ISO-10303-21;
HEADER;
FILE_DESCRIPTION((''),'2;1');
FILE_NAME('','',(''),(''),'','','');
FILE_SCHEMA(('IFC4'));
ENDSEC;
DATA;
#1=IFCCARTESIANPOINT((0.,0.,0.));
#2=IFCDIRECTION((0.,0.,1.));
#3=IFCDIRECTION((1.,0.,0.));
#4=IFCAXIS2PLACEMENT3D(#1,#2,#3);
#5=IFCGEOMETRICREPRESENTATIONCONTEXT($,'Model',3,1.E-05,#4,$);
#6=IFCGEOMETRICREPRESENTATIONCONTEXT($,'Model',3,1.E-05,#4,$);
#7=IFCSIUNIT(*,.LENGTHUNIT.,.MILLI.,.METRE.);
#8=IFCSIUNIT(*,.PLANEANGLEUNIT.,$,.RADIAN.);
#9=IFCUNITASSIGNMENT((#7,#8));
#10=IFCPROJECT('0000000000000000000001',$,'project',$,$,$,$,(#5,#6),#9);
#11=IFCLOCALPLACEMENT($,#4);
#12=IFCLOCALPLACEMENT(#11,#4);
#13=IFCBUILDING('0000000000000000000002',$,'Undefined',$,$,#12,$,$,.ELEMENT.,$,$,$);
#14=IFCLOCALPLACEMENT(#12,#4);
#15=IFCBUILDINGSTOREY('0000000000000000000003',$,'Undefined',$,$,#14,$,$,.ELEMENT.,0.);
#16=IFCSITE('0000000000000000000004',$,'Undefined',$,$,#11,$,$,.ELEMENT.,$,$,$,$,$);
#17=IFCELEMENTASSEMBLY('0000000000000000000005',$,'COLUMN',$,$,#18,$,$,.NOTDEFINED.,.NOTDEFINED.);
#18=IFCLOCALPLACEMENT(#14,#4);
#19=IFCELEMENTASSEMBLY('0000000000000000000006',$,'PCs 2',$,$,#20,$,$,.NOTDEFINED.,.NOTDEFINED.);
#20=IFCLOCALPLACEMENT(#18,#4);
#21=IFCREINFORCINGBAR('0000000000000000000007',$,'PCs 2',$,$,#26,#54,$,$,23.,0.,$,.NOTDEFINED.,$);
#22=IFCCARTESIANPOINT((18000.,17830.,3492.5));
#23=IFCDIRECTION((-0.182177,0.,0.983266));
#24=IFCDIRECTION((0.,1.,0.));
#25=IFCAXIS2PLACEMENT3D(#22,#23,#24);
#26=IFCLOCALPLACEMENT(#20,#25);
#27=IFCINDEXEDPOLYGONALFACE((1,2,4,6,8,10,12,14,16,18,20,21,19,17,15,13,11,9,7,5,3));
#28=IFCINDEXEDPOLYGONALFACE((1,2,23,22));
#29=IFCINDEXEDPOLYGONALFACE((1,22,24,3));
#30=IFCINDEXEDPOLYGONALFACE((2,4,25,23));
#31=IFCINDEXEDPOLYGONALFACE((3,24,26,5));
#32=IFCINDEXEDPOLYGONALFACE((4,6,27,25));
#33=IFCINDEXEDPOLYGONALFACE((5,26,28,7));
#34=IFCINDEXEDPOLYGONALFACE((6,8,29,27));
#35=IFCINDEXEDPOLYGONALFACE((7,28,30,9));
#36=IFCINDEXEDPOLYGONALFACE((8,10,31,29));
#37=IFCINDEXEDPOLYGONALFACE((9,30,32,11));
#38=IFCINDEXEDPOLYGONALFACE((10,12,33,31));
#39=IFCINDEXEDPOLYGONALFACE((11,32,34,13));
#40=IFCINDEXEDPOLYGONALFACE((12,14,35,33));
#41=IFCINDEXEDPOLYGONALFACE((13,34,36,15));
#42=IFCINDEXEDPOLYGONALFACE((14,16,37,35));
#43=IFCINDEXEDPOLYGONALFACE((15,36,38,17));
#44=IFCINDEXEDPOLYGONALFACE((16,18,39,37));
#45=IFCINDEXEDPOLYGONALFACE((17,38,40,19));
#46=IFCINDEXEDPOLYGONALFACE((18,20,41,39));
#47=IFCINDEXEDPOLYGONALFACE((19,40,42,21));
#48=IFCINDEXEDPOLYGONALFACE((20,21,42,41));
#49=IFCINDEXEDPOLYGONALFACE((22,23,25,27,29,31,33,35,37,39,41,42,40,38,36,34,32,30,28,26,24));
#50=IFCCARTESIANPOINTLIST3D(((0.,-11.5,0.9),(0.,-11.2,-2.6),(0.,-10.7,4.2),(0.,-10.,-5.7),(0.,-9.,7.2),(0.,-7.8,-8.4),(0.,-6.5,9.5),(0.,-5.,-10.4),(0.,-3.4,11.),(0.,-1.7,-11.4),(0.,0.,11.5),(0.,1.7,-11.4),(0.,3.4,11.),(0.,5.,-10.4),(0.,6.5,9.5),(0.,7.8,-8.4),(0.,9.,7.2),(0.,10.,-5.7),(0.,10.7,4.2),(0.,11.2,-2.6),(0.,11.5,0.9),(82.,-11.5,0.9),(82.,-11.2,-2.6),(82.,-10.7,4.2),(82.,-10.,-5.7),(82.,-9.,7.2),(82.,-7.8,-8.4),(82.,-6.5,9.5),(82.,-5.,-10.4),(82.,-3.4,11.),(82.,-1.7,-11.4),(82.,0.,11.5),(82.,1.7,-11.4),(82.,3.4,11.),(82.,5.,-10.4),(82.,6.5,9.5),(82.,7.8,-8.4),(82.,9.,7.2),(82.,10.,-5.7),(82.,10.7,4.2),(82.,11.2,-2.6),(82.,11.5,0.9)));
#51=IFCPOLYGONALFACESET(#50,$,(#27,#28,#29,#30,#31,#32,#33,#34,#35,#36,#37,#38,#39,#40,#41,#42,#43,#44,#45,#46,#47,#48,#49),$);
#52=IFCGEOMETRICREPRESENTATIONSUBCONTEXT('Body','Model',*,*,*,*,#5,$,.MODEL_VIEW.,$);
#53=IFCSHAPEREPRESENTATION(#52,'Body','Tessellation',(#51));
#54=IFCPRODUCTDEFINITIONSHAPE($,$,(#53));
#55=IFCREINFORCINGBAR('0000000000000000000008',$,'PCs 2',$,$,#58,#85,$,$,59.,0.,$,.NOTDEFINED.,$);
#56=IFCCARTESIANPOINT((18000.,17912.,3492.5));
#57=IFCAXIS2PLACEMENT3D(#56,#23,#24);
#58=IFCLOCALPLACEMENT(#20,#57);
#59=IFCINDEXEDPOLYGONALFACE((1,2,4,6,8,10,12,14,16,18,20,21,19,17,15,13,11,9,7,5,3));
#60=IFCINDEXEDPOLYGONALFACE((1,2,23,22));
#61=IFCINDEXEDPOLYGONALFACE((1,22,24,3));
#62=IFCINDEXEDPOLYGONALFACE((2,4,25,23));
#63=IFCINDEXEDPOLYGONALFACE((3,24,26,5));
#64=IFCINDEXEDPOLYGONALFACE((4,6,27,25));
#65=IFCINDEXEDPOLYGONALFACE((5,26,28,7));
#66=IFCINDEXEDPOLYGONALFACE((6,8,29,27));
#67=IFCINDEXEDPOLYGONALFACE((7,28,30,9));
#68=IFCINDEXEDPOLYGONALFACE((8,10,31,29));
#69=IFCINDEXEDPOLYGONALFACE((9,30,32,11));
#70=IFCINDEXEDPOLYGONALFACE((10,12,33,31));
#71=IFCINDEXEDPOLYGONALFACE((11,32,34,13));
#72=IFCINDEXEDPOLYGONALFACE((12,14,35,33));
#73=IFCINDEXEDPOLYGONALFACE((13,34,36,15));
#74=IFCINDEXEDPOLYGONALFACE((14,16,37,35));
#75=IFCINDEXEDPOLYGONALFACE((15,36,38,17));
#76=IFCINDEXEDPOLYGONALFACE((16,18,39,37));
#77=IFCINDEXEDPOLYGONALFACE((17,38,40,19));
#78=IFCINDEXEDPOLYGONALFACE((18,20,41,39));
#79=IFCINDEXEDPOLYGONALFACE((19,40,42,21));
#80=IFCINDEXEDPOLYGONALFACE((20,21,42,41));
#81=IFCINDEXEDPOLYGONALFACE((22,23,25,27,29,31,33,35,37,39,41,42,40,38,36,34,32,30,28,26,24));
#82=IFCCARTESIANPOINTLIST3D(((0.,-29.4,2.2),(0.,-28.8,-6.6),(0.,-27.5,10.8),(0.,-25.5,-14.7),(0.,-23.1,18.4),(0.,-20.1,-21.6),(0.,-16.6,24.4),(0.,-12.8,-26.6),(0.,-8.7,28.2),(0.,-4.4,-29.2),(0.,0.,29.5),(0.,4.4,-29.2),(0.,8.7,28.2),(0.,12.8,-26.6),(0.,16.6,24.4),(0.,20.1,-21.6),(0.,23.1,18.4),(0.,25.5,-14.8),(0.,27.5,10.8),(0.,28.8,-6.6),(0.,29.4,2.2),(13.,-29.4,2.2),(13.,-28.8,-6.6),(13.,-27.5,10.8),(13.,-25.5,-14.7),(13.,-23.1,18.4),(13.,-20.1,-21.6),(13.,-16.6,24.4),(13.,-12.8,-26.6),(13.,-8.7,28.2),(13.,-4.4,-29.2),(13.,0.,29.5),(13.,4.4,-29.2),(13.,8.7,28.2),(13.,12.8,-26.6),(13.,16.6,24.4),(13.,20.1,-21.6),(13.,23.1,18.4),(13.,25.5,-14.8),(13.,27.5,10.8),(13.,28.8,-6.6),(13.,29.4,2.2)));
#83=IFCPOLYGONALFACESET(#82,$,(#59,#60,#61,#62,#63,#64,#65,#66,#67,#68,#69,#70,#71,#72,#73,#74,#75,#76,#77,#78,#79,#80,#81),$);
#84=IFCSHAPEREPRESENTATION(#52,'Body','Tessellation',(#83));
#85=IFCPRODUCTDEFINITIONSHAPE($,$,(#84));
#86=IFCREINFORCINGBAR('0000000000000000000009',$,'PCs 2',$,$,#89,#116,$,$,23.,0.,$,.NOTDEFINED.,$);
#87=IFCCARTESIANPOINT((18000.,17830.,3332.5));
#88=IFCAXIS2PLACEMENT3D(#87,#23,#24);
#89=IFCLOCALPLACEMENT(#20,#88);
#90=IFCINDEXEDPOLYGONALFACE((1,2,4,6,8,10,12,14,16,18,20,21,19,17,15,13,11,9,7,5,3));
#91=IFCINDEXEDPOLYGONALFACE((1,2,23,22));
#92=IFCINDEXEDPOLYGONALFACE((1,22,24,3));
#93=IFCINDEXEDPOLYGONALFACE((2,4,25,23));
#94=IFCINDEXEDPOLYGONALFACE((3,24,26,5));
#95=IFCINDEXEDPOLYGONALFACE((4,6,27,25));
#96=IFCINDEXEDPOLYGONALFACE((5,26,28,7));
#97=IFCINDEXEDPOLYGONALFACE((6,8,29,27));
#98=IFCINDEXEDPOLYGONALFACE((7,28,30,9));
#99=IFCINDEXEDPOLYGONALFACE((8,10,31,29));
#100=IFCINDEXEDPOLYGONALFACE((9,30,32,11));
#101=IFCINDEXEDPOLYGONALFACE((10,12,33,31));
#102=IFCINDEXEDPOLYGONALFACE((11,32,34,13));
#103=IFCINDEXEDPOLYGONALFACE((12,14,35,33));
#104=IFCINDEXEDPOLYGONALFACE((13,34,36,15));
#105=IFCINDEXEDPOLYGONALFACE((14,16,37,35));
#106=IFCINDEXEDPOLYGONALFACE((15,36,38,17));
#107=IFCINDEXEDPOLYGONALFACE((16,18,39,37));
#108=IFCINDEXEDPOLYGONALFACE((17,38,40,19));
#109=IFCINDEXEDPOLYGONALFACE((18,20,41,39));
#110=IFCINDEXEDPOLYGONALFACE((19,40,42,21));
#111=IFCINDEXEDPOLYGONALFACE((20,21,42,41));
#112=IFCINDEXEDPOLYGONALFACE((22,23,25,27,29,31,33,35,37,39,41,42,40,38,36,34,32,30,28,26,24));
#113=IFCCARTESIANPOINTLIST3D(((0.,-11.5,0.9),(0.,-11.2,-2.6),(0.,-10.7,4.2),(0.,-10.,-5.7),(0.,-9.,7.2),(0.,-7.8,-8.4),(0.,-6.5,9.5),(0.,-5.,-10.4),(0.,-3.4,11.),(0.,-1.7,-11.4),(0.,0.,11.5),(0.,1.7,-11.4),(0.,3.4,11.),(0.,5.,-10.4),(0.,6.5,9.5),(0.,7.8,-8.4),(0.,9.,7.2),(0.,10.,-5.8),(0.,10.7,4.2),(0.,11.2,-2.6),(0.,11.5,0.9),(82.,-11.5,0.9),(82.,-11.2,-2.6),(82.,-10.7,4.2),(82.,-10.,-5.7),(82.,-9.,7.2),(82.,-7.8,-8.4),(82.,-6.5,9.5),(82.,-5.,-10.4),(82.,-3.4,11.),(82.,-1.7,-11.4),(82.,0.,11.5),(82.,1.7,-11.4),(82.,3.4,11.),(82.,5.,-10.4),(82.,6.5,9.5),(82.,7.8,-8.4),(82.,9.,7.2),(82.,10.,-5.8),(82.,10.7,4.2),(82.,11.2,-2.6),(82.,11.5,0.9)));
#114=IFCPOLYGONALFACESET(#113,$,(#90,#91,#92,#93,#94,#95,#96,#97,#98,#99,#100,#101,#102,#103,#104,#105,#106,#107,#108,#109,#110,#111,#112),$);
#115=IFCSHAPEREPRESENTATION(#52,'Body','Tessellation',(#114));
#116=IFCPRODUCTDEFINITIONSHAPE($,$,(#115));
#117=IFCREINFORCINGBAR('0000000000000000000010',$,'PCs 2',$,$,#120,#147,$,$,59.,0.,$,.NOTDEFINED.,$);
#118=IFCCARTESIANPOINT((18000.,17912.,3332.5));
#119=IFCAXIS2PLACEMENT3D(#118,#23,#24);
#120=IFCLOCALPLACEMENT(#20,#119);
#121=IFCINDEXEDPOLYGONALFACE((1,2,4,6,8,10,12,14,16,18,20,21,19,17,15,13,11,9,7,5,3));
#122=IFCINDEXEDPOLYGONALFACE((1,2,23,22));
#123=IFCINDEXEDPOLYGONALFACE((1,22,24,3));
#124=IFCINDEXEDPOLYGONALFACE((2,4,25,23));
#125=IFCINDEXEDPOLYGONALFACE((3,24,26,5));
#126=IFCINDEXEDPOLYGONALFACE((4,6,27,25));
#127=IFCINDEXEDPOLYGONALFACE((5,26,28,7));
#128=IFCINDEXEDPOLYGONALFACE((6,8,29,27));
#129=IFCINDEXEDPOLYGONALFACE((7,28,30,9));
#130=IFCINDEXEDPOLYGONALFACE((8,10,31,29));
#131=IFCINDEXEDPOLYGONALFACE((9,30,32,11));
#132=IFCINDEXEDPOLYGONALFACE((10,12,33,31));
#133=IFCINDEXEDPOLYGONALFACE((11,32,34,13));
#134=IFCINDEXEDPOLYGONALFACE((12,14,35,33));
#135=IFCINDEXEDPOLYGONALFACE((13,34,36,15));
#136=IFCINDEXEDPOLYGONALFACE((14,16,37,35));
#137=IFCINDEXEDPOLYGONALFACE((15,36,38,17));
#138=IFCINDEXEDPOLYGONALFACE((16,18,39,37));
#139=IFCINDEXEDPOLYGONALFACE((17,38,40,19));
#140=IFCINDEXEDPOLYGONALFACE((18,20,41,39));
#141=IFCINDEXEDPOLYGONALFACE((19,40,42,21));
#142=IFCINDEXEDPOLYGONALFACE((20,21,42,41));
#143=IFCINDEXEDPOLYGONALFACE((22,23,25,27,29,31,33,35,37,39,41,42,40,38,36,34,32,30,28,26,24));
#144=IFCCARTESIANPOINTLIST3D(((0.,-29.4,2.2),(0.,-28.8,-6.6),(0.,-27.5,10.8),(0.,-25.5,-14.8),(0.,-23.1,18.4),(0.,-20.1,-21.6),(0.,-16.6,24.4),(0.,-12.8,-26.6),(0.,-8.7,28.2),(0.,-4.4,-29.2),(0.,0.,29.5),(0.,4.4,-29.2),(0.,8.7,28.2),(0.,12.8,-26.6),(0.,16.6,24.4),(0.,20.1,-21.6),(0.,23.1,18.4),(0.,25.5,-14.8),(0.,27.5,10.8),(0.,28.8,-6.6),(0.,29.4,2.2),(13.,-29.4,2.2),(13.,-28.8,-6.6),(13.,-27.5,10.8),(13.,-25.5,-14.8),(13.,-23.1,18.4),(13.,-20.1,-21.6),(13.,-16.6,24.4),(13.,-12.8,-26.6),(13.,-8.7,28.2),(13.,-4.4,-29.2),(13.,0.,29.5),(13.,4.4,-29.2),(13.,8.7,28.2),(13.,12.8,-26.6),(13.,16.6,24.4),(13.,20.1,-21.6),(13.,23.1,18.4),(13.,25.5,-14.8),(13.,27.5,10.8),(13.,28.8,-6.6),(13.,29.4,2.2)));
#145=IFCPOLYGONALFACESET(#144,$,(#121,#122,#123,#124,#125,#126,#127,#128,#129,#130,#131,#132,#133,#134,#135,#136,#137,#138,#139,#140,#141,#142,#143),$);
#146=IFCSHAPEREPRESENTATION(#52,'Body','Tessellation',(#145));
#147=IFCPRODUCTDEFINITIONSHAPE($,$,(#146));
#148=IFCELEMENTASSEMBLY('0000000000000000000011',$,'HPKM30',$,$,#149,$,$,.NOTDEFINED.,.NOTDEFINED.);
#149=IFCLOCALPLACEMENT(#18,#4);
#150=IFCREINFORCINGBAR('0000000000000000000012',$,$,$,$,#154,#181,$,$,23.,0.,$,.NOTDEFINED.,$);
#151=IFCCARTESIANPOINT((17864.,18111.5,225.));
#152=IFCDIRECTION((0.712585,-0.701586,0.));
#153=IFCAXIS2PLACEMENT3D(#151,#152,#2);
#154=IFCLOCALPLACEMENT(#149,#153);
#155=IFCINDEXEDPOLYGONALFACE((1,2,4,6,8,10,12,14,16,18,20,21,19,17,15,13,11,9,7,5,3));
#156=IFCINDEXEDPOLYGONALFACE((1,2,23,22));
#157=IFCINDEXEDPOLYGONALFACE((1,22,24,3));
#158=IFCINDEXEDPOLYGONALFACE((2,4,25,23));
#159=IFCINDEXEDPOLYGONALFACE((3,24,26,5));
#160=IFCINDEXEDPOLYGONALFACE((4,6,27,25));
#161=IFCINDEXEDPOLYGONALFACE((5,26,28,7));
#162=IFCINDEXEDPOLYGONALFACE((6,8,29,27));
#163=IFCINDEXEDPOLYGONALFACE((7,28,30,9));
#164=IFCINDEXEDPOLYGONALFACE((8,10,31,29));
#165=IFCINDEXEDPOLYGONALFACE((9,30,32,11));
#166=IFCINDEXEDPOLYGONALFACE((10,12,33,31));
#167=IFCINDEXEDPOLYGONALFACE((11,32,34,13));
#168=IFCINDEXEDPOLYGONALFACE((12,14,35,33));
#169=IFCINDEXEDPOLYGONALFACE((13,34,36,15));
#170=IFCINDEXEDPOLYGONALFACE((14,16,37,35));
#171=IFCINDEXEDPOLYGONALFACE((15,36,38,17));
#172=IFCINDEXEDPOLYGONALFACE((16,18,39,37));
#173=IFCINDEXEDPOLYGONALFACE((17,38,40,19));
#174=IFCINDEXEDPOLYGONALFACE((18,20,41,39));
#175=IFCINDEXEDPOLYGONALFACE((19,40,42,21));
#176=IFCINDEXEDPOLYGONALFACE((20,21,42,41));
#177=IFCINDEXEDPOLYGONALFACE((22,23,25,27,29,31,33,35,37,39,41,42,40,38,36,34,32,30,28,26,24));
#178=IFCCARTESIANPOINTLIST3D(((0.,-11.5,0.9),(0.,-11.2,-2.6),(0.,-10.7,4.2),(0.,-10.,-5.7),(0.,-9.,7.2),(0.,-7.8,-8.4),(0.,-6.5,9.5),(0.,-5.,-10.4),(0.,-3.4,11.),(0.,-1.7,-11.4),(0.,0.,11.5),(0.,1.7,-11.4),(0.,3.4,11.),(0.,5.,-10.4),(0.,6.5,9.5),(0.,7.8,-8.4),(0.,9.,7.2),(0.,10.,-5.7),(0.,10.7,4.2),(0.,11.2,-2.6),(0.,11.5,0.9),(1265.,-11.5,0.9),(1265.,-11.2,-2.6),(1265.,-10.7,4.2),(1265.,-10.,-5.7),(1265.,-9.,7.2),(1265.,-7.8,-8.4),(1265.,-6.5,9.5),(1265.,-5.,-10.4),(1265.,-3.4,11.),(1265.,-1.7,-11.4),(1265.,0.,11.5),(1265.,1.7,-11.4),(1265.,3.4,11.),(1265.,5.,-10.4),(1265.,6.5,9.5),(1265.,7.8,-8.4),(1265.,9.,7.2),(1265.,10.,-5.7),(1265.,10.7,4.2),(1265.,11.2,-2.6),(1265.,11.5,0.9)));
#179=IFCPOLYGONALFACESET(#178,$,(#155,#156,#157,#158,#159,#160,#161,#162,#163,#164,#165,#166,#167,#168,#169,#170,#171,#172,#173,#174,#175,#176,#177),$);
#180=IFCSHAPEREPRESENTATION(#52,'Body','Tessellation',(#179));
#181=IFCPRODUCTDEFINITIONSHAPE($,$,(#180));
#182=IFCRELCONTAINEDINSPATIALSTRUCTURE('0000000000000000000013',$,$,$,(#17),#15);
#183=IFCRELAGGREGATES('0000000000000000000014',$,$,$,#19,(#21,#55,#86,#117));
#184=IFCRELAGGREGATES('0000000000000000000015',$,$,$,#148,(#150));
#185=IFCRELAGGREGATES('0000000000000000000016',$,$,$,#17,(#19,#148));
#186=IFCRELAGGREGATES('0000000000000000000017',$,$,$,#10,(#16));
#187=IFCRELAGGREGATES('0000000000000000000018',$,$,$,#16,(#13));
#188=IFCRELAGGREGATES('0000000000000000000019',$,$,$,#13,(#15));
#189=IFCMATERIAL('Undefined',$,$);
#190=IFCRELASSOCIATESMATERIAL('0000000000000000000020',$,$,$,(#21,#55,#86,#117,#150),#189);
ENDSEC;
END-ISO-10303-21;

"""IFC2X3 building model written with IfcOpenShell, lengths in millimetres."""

from ifc_helpers import new_model, entity, si_unit, frame, origin_with_axes, place, context, subcontext, project, spatial, source, transform, mapped, material, element, aggregate, save


model = new_model("IFC2X3")

# Units and contexts
model_context_1 = context("Model", 3, precision=1e-05, world=origin_with_axes())
model_context_2 = context("Model", 3, precision=1e-05, world=origin_with_axes())
body_context = subcontext(model_context_1, "Body", "Model", "MODEL_VIEW")
ifc_project = project(units=[si_unit("LENGTHUNIT", "METRE", prefix="MILLI"), si_unit("PLANEANGLEUNIT", "RADIAN")], contexts=[model_context_1, model_context_2])

# Site, building, storey
site_placement = place(None, origin_with_axes())
site = spatial("IfcSite", under=ifc_project, at=site_placement, Name="Undefined", CompositionType="ELEMENT")
building_placement = place(site_placement, origin_with_axes())
building = spatial("IfcBuilding", under=site, at=building_placement, Name="Undefined", CompositionType="ELEMENT")
storey_placement = place(building_placement, origin_with_axes())
storey = spatial("IfcBuildingStorey", under=building, at=storey_placement, Name="Undefined", CompositionType="ELEMENT", Elevation=0.0)

# Element assemblies
assembly_1_placement = place(storey_placement, origin_with_axes())
assembly_1 = element("IfcElementAssembly", 1, at=assembly_1_placement, inside=storey, Name="COLUMN", AssemblyPlace="NOTDEFINED", PredefinedType="NOTDEFINED")
assembly_2_placement = place(assembly_1_placement, origin_with_axes())
assembly_2 = element("IfcElementAssembly", 2, at=assembly_2_placement, Name="PCs 2", AssemblyPlace="NOTDEFINED", PredefinedType="NOTDEFINED")

# Reinforcing bars
ifc_material_1 = material(Name="Undefined")
shared_shape_1 = source(origin_with_axes(), body_context, "Body", "AdvancedSweptSolid", [
    entity("IfcSweptDiskSolid", entity("IfcTrimmedCurve", entity("IfcLine", entity("IfcCartesianPoint", [0.0, 0.0, 0.0]), entity("IfcVector", entity("IfcDirection", [1.0, 0.0, 0.0]), 1.0)), [entity("IfcParameterValue", 0.0)], [entity("IfcParameterValue", 82.0)], True, "PARAMETER"), 11.5, None, 0.0, 82.0),
])
reinforcing_bar_1_placement = place(assembly_2_placement, frame((18000.0, 17830.0, 3492.5), z_axis=(-0.182177, 0.0, 0.983266), x_axis=(0.0, 1.0, 0.0)))
reinforcing_bar_1 = element("IfcReinforcingBar", 3, at=reinforcing_bar_1_placement, material=ifc_material_1, Name="PCs 2", BarRole="NOTDEFINED", CrossSectionArea=0.0, NominalDiameter=23.0, context=body_context, shape_type="MappedRepresentation", body=[
    mapped(shared_shape_1, transform((0.0, 0.0, 0.0))),
])
shared_shape_2 = source(origin_with_axes(), body_context, "Body", "AdvancedSweptSolid", [
    entity("IfcSweptDiskSolid", entity("IfcTrimmedCurve", entity("IfcLine", entity("IfcCartesianPoint", [0.0, 0.0, 0.0]), entity("IfcVector", entity("IfcDirection", [1.0, 0.0, 0.0]), 1.0)), [entity("IfcParameterValue", 0.0)], [entity("IfcParameterValue", 13.0)], True, "PARAMETER"), 29.5, None, 0.0, 13.0),
])
reinforcing_bar_2_placement = place(assembly_2_placement, frame((18000.0, 17912.0, 3492.5), z_axis=(-0.182177, 0.0, 0.983266), x_axis=(0.0, 1.0, 0.0)))
reinforcing_bar_2 = element("IfcReinforcingBar", 4, at=reinforcing_bar_2_placement, material=ifc_material_1, Name="PCs 2", BarRole="NOTDEFINED", CrossSectionArea=0.0, NominalDiameter=59.0, context=body_context, shape_type="MappedRepresentation", body=[
    mapped(shared_shape_2, transform((0.0, 0.0, 0.0))),
])
shared_shape_3 = source(origin_with_axes(), body_context, "Body", "AdvancedSweptSolid", [
    entity("IfcSweptDiskSolid", entity("IfcTrimmedCurve", entity("IfcLine", entity("IfcCartesianPoint", [0.0, 0.0, 0.0]), entity("IfcVector", entity("IfcDirection", [1.0, 0.0, 0.0]), 1.0)), [entity("IfcParameterValue", 0.0)], [entity("IfcParameterValue", 82.0)], True, "PARAMETER"), 11.5, None, 0.0, 82.0),
])
reinforcing_bar_3_placement = place(assembly_2_placement, frame((18000.0, 17830.0, 3332.5), z_axis=(-0.182177, 0.0, 0.983266), x_axis=(0.0, 1.0, 0.0)))
reinforcing_bar_3 = element("IfcReinforcingBar", 5, at=reinforcing_bar_3_placement, material=ifc_material_1, Name="PCs 2", BarRole="NOTDEFINED", CrossSectionArea=0.0, NominalDiameter=23.0, context=body_context, shape_type="MappedRepresentation", body=[
    mapped(shared_shape_3, transform((0.0, 0.0, 0.0))),
])
shared_shape_4 = source(origin_with_axes(), body_context, "Body", "AdvancedSweptSolid", [
    entity("IfcSweptDiskSolid", entity("IfcTrimmedCurve", entity("IfcLine", entity("IfcCartesianPoint", [0.0, 0.0, 0.0]), entity("IfcVector", entity("IfcDirection", [1.0, 0.0, 0.0]), 1.0)), [entity("IfcParameterValue", 0.0)], [entity("IfcParameterValue", 13.0)], True, "PARAMETER"), 29.5, None, 0.0, 13.0),
])
reinforcing_bar_4_placement = place(assembly_2_placement, frame((18000.0, 17912.0, 3332.5), z_axis=(-0.182177, 0.0, 0.983266), x_axis=(0.0, 1.0, 0.0)))
reinforcing_bar_4 = element("IfcReinforcingBar", 6, at=reinforcing_bar_4_placement, material=ifc_material_1, Name="PCs 2", BarRole="NOTDEFINED", CrossSectionArea=0.0, NominalDiameter=59.0, context=body_context, shape_type="MappedRepresentation", body=[
    mapped(shared_shape_4, transform((0.0, 0.0, 0.0))),
])
aggregate(assembly_2, [reinforcing_bar_1, reinforcing_bar_2, reinforcing_bar_3, reinforcing_bar_4])

# Element assembly, reinforcing bar
assembly_3_placement = place(assembly_1_placement, origin_with_axes())
assembly_3 = element("IfcElementAssembly", 7, at=assembly_3_placement, Name="HPKM30", AssemblyPlace="NOTDEFINED", PredefinedType="NOTDEFINED")
shared_shape_5 = source(origin_with_axes(), body_context, "Body", "AdvancedSweptSolid", [
    entity("IfcSweptDiskSolid", entity("IfcTrimmedCurve", entity("IfcLine", entity("IfcCartesianPoint", [0.0, 0.0, 0.0]), entity("IfcVector", entity("IfcDirection", [1.0, 0.0, 0.0]), 1.0)), [entity("IfcParameterValue", 0.0)], [entity("IfcParameterValue", 1265.0)], True, "PARAMETER"), 11.5, None, 0.0, 1265.0),
])
reinforcing_bar_5_placement = place(assembly_3_placement, frame((17864.0, 18111.5, 225.0), z_axis=(0.712585, -0.701586, 0.0), x_axis=(0.0, 0.0, 1.0)))
reinforcing_bar_5 = element("IfcReinforcingBar", 8, at=reinforcing_bar_5_placement, material=ifc_material_1, BarRole="NOTDEFINED", CrossSectionArea=0.0, NominalDiameter=23.0, context=body_context, shape_type="MappedRepresentation", body=[
    mapped(shared_shape_5, transform((0.0, 0.0, 0.0))),
])
aggregate(assembly_3, [reinforcing_bar_5])

aggregate(assembly_1, [assembly_2, assembly_3])

save(model, "model.ifc")
